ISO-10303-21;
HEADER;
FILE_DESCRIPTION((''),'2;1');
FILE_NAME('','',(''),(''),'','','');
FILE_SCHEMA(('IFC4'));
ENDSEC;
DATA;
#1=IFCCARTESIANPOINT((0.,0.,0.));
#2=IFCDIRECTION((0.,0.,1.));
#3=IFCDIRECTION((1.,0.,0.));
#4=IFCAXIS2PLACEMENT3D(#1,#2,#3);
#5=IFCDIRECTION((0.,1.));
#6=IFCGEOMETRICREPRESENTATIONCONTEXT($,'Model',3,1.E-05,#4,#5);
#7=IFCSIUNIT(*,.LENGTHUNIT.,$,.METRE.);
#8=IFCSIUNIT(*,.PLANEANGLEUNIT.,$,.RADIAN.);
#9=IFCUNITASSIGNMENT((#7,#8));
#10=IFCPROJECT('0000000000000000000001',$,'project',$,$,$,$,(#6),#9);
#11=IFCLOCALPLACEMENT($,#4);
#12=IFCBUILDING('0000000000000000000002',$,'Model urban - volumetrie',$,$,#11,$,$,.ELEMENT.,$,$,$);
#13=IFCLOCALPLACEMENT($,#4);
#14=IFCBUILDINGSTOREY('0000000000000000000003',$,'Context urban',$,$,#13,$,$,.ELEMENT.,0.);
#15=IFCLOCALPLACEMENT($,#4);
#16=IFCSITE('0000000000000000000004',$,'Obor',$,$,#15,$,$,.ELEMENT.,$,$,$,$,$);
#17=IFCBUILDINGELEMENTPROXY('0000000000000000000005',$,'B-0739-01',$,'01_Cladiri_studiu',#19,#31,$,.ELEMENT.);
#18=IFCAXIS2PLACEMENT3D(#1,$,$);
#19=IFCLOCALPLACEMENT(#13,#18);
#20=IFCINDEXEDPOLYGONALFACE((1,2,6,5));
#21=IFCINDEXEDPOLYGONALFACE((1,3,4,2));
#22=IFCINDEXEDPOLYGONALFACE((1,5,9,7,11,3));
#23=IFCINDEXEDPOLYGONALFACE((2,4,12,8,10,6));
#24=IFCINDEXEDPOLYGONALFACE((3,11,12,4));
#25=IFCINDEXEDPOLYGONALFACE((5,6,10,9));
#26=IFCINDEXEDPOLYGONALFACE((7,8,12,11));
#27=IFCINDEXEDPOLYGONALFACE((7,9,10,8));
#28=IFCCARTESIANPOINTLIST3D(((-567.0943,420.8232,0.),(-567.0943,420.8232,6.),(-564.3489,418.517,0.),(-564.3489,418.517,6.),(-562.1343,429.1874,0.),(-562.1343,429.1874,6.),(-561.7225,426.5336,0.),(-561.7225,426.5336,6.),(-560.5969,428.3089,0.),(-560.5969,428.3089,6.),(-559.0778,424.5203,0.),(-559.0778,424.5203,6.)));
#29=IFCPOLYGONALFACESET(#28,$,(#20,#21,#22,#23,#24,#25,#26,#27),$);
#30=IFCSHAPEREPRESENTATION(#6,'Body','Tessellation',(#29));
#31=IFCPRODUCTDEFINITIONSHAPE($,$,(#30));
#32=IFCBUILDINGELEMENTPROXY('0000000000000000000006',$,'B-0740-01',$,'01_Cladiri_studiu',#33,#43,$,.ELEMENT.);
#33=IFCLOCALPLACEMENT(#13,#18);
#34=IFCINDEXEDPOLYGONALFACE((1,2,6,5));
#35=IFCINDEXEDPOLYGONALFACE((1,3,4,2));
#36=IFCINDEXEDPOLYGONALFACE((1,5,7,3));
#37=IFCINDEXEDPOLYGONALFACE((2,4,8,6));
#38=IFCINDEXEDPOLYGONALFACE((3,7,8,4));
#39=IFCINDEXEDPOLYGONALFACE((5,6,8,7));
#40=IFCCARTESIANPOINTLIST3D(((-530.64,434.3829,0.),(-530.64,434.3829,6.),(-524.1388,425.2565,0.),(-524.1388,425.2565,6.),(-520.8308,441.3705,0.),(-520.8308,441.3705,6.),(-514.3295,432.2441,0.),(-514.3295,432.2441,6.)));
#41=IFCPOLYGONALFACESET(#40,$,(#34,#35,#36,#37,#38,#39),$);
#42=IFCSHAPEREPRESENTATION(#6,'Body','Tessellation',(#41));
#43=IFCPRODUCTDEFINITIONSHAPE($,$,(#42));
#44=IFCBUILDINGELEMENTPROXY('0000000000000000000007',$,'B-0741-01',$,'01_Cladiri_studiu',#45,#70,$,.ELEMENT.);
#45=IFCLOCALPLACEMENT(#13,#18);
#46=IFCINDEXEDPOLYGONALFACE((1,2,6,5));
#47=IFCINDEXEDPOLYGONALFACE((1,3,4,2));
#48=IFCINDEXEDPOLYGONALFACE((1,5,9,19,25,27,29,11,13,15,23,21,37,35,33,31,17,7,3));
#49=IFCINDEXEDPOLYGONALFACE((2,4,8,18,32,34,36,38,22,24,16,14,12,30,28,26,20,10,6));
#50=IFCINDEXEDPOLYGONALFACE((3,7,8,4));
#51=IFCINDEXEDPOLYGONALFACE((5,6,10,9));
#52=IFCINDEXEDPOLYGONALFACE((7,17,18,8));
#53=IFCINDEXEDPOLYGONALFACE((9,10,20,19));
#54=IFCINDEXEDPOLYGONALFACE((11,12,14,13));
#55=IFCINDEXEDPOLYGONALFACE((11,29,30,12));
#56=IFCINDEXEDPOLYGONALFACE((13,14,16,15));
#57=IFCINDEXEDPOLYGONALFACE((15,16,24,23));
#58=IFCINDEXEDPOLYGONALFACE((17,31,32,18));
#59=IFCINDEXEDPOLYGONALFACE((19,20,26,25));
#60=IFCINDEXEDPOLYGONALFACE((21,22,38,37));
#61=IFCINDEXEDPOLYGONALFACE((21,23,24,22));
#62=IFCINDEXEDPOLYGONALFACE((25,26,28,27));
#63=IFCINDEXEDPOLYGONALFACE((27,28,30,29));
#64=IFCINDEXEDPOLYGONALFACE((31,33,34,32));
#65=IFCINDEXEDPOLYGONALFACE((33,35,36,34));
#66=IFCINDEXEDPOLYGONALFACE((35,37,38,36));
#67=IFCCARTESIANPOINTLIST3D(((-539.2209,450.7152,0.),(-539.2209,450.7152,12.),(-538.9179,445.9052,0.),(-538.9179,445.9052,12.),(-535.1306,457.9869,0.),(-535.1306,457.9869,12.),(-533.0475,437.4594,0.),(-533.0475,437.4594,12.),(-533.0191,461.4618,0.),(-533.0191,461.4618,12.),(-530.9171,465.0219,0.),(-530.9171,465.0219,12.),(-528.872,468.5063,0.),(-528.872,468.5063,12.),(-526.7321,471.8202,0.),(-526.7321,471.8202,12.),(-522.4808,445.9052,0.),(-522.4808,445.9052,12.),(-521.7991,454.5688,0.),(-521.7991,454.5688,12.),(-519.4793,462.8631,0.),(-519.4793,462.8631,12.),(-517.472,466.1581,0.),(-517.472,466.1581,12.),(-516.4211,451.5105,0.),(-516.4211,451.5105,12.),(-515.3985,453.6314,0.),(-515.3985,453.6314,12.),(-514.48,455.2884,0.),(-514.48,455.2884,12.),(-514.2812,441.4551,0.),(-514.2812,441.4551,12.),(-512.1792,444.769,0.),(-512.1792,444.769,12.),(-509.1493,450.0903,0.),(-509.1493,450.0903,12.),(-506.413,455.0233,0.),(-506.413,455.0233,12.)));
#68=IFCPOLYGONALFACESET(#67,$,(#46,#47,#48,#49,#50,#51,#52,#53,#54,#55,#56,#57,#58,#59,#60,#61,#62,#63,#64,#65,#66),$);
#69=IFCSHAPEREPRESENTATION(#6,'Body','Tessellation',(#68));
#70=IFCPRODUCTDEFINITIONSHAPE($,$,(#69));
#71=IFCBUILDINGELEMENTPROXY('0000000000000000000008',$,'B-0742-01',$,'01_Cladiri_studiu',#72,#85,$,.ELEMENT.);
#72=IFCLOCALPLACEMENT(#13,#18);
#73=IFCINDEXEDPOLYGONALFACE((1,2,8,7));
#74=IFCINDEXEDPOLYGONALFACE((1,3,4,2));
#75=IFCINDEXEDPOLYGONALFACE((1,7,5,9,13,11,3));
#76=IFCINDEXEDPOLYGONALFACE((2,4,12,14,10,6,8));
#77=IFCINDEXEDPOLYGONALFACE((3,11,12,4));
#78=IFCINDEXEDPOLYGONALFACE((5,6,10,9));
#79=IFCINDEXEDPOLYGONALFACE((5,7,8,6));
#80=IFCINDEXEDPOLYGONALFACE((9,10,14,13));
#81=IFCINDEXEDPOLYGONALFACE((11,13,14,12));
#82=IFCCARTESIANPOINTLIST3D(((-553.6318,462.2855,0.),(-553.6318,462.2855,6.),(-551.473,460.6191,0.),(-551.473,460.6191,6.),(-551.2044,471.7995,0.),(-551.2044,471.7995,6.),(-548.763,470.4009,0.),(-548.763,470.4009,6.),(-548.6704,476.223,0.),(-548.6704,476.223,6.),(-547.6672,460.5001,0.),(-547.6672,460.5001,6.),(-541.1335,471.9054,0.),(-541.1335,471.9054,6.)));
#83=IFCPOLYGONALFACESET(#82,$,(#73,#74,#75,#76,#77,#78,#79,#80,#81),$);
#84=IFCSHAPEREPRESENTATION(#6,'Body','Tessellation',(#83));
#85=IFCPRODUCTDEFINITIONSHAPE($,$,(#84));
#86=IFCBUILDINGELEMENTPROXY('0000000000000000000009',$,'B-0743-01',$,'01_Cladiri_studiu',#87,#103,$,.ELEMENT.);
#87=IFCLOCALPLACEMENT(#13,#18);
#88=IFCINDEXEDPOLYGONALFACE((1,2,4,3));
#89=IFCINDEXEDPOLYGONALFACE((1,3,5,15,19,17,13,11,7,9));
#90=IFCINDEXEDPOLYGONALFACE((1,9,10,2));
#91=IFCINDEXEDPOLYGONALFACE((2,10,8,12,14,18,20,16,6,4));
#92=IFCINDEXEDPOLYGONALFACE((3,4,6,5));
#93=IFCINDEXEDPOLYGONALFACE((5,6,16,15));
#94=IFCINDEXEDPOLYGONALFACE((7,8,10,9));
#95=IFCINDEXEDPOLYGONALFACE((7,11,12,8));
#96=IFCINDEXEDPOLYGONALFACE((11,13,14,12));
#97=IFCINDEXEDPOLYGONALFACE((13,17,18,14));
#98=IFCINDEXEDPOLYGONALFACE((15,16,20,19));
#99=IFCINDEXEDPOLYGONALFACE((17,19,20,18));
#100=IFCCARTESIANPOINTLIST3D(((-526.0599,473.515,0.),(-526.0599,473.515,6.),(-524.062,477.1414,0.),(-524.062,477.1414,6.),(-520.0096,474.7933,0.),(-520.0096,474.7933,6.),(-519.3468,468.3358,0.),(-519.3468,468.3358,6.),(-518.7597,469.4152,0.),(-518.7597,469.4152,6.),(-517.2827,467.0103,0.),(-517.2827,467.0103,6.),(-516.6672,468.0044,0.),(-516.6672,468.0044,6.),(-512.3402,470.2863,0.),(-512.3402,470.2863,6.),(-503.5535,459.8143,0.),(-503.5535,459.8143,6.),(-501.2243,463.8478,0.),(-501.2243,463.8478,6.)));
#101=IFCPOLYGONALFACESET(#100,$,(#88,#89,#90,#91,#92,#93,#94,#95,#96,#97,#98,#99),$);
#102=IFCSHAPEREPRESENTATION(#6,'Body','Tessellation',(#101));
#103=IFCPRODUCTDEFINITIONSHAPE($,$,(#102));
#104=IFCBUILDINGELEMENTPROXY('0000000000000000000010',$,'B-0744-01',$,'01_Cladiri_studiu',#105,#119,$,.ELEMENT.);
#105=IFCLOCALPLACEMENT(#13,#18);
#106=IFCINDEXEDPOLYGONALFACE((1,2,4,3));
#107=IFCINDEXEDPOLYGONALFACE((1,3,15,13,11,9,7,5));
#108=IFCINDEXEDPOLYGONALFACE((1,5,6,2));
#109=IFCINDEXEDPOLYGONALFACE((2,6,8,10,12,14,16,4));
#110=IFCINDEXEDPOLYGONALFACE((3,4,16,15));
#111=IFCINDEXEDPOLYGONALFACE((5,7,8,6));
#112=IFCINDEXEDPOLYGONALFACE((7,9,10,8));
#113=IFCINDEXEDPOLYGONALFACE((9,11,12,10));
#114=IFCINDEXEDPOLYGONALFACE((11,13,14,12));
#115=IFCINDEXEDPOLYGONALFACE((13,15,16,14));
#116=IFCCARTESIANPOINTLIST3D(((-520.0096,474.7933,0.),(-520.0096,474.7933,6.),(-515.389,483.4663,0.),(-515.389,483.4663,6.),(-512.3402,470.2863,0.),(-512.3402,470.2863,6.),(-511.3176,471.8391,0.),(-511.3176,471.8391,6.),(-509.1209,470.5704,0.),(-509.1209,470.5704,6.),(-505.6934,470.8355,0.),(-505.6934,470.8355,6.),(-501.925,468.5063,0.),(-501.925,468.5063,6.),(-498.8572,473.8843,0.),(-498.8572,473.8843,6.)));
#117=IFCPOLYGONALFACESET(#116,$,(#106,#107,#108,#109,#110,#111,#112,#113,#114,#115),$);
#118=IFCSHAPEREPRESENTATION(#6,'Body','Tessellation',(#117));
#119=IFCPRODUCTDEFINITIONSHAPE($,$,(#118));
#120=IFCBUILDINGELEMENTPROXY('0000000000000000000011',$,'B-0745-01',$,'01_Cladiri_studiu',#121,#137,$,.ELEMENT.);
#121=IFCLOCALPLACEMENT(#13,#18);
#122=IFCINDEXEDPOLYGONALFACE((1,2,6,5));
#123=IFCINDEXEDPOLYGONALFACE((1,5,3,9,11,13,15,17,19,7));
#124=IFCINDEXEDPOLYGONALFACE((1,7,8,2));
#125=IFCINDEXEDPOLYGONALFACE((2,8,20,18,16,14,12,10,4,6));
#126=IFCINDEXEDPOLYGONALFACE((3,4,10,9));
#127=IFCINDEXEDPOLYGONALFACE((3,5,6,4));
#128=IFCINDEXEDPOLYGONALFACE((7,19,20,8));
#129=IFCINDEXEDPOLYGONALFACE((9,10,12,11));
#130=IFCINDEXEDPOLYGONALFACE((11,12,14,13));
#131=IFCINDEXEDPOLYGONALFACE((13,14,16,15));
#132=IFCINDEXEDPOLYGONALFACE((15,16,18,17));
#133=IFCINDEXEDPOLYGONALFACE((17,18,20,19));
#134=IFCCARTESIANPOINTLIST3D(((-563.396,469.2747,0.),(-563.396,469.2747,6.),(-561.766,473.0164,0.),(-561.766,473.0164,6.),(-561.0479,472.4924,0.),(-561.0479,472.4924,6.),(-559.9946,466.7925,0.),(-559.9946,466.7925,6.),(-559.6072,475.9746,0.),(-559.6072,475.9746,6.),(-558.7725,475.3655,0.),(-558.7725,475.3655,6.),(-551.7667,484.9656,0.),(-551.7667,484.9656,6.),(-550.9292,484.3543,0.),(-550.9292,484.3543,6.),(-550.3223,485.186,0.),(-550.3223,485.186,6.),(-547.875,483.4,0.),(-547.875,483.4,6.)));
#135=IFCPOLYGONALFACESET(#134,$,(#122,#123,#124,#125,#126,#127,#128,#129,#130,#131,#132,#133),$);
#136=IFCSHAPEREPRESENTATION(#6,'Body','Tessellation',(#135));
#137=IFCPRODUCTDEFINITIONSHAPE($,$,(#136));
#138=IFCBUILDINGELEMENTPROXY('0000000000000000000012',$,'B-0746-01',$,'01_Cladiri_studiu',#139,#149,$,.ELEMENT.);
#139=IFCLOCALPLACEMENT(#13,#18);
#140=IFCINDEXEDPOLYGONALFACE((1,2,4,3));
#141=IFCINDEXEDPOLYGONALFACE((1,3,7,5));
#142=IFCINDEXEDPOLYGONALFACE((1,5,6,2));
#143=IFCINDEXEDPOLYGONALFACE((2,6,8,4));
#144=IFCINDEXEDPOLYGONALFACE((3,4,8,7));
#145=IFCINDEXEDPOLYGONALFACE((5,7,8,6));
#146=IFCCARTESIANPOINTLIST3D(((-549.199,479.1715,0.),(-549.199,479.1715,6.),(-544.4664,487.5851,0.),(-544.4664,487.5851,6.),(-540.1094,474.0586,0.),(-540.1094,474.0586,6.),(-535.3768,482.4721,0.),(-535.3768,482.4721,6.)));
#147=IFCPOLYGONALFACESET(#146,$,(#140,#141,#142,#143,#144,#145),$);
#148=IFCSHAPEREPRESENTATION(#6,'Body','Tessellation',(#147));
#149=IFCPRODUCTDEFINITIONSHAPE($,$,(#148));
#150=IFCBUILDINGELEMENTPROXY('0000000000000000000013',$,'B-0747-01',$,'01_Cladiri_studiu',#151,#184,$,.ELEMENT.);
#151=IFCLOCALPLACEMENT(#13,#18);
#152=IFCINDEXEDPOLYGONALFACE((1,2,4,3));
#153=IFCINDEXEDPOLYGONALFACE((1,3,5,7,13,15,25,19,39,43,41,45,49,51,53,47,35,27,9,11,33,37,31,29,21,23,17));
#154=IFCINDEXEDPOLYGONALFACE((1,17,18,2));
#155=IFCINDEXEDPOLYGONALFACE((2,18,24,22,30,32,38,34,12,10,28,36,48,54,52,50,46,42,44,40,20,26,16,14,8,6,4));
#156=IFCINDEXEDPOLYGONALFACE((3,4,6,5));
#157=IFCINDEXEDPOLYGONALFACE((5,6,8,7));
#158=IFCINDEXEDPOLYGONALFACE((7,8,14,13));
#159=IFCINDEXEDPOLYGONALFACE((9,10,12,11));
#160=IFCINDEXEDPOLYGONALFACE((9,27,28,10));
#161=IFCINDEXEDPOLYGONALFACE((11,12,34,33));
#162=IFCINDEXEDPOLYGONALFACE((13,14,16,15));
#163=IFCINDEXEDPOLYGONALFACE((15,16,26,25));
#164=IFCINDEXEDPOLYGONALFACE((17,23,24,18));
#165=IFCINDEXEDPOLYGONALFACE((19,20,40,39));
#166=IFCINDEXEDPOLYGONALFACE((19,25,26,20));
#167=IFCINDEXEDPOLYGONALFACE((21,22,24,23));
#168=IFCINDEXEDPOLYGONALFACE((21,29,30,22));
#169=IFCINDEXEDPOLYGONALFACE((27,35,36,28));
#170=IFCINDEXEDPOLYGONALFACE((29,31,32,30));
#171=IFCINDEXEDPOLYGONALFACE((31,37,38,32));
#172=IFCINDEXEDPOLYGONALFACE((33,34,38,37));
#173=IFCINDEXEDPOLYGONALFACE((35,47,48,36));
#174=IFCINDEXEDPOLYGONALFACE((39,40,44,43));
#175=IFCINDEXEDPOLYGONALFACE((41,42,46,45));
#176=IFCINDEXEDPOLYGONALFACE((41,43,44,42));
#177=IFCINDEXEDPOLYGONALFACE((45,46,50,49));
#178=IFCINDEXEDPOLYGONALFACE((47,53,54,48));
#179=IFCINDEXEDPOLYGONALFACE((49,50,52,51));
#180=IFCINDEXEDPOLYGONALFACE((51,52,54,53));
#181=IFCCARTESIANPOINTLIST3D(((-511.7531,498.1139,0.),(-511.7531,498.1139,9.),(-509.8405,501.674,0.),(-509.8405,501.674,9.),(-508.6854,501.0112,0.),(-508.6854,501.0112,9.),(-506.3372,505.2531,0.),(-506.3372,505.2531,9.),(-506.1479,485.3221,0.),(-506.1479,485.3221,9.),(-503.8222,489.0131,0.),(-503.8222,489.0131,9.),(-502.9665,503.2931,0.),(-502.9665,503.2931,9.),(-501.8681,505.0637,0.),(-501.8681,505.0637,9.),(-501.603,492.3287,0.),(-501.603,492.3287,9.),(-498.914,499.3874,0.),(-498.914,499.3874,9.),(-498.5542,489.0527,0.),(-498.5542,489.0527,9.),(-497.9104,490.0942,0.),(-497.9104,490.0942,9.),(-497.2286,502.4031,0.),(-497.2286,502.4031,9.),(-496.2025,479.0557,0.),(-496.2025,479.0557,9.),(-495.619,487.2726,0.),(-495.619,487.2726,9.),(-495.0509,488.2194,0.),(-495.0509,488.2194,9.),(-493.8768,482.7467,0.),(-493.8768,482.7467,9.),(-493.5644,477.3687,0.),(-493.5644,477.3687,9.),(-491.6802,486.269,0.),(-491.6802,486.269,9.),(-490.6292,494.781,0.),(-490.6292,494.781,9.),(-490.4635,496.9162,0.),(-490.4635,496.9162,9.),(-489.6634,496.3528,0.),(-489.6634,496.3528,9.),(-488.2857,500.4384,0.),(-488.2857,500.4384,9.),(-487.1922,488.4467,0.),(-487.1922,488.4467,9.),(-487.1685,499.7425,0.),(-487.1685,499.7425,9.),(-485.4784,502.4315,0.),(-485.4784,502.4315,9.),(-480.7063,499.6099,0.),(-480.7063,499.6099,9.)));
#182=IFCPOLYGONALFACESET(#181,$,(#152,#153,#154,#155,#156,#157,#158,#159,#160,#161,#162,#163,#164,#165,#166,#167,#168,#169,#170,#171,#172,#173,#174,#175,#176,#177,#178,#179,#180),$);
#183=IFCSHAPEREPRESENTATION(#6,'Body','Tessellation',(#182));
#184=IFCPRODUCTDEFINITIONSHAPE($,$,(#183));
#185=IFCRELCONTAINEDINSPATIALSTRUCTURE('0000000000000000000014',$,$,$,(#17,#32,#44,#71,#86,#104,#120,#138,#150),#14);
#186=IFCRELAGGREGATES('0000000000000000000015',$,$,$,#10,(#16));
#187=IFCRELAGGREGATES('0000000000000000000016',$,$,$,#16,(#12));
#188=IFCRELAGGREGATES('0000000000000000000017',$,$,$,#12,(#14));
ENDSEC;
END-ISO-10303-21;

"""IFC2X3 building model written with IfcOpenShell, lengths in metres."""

from ifc_helpers import new_model, si_unit, direction, origin_with_axes, place, context, project, spatial, polyline, outline, extrude, element, save


model = new_model("IFC2X3")

# Units and contexts
model_context = context("Model", 3, precision=1e-05, world=origin_with_axes(), true_north=direction((0.0, 1.0)))
ifc_project = project(units=[si_unit("LENGTHUNIT", "METRE"), si_unit("PLANEANGLEUNIT", "RADIAN")], contexts=[model_context])

# Site, building, storey
site_placement = place(None, origin_with_axes())
site = spatial("IfcSite", under=ifc_project, at=site_placement, Name="Obor", CompositionType="ELEMENT")
building_placement = place(None, origin_with_axes())
building = spatial("IfcBuilding", under=site, at=building_placement, Name="Model urban - volumetrie", CompositionType="ELEMENT")
storey_placement = place(None, origin_with_axes())
storey = spatial("IfcBuildingStorey", under=building, at=storey_placement, Name="Context urban", CompositionType="ELEMENT", Elevation=0.0)

# Building element proxies
proxy_1_placement = place(None, origin_with_axes())
element("IfcBuildingElementProxy", 1, at=proxy_1_placement, inside=storey, Name="B-0739-01", ObjectType="01_Cladiri_studiu", CompositionType="ELEMENT", context=model_context, shape_type="SweptSolid", body=[
    extrude(outline(polyline([(-560.5969, 428.3089), (-562.1343, 429.1874), (-567.0943, 420.8232), (-564.3489, 418.517), (-559.0778, 424.5203), (-561.7225, 426.5336), (-560.5969, 428.3089)])), origin_with_axes(), (0.0, 0.0, 1.0), 6.0),
])
proxy_2_placement = place(None, origin_with_axes())
element("IfcBuildingElementProxy", 2, at=proxy_2_placement, inside=storey, Name="B-0740-01", ObjectType="01_Cladiri_studiu", CompositionType="ELEMENT", context=model_context, shape_type="SweptSolid", body=[
    extrude(outline(polyline([(-514.3295, 432.2441), (-520.8308, 441.3705), (-530.64, 434.3829), (-524.1388, 425.2565), (-514.3295, 432.2441)])), origin_with_axes(), (0.0, 0.0, 1.0), 6.0),
])
proxy_3_placement = place(None, origin_with_axes())
element("IfcBuildingElementProxy", 3, at=proxy_3_placement, inside=storey, Name="B-0741-01", ObjectType="01_Cladiri_studiu", CompositionType="ELEMENT", context=model_context, shape_type="SweptSolid", body=[
    extrude(outline(polyline([(-517.472, 466.1581), (-526.7321, 471.8202), (-528.872, 468.5063), (-530.9171, 465.0219), (-514.48, 455.2884), (-515.3985, 453.6314), (-516.4211, 451.5105), (-521.7991, 454.5688), (-533.0191, 461.4618), (-535.1306, 457.9869), (-539.2209, 450.7152), (-538.9179, 445.9052), (-533.0475, 437.4594), (-522.4808, 445.9052), (-514.2812, 441.4551), (-512.1792, 444.769), (-509.1493, 450.0903), (-506.413, 455.0233), (-519.4793, 462.8631), (-517.472, 466.1581)])), origin_with_axes(), (0.0, 0.0, 1.0), 12.0),
])
proxy_4_placement = place(None, origin_with_axes())
element("IfcBuildingElementProxy", 4, at=proxy_4_placement, inside=storey, Name="B-0742-01", ObjectType="01_Cladiri_studiu", CompositionType="ELEMENT", context=model_context, shape_type="SweptSolid", body=[
    extrude(outline(polyline([(-541.1335, 471.9054), (-548.6704, 476.223), (-551.2044, 471.7995), (-548.763, 470.4009), (-553.6318, 462.2855), (-551.473, 460.6191), (-547.6672, 460.5001), (-541.1335, 471.9054)])), origin_with_axes(), (0.0, 0.0, 1.0), 6.0),
])
proxy_5_placement = place(None, origin_with_axes())
element("IfcBuildingElementProxy", 5, at=proxy_5_placement, inside=storey, Name="B-0743-01", ObjectType="01_Cladiri_studiu", CompositionType="ELEMENT", context=model_context, shape_type="SweptSolid", body=[
    extrude(outline(polyline([(-516.6672, 468.0044), (-503.5535, 459.8143), (-501.2243, 463.8478), (-512.3402, 470.2863), (-520.0096, 474.7933), (-524.062, 477.1414), (-526.0599, 473.515), (-518.7597, 469.4152), (-519.3468, 468.3358), (-517.2827, 467.0103), (-516.6672, 468.0044)])), origin_with_axes(), (0.0, 0.0, 1.0), 6.0),
])
proxy_6_placement = place(None, origin_with_axes())
element("IfcBuildingElementProxy", 6, at=proxy_6_placement, inside=storey, Name="B-0744-01", ObjectType="01_Cladiri_studiu", CompositionType="ELEMENT", context=model_context, shape_type="SweptSolid", body=[
    extrude(outline(polyline([(-511.3176, 471.8391), (-509.1209, 470.5704), (-505.6934, 470.8355), (-501.925, 468.5063), (-498.8572, 473.8843), (-515.389, 483.4663), (-520.0096, 474.7933), (-512.3402, 470.2863), (-511.3176, 471.8391)])), origin_with_axes(), (0.0, 0.0, 1.0), 6.0),
])
proxy_7_placement = place(None, origin_with_axes())
element("IfcBuildingElementProxy", 7, at=proxy_7_placement, inside=storey, Name="B-0745-01", ObjectType="01_Cladiri_studiu", CompositionType="ELEMENT", context=model_context, shape_type="SweptSolid", body=[
    extrude(outline(polyline([(-559.6072, 475.9746), (-561.766, 473.0164), (-561.0479, 472.4924), (-563.396, 469.2747), (-559.9946, 466.7925), (-547.875, 483.4), (-550.3223, 485.186), (-550.9292, 484.3543), (-551.7667, 484.9656), (-558.7725, 475.3655), (-559.6072, 475.9746)])), origin_with_axes(), (0.0, 0.0, 1.0), 6.0),
])
proxy_8_placement = place(None, origin_with_axes())
element("IfcBuildingElementProxy", 8, at=proxy_8_placement, inside=storey, Name="B-0746-01", ObjectType="01_Cladiri_studiu", CompositionType="ELEMENT", context=model_context, shape_type="SweptSolid", body=[
    extrude(outline(polyline([(-540.1094, 474.0586), (-535.3768, 482.4721), (-544.4664, 487.5851), (-549.199, 479.1715), (-540.1094, 474.0586)])), origin_with_axes(), (0.0, 0.0, 1.0), 6.0),
])
proxy_9_placement = place(None, origin_with_axes())
element("IfcBuildingElementProxy", 9, at=proxy_9_placement, inside=storey, Name="B-0747-01", ObjectType="01_Cladiri_studiu", CompositionType="ELEMENT", context=model_context, shape_type="SweptSolid", body=[
    extrude(outline(polyline([(-495.0509, 488.2194), (-491.6802, 486.269), (-493.8768, 482.7467), (-503.8222, 489.0131), (-506.1479, 485.3221), (-496.2025, 479.0557), (-493.5644, 477.3687), (-487.1922, 488.4467), (-480.7063, 499.6099), (-485.4784, 502.4315), (-487.1685, 499.7425), (-488.2857, 500.4384), (-490.4635, 496.9162), (-489.6634, 496.3528), (-490.6292, 494.781), (-498.914, 499.3874), (-497.2286, 502.4031), (-501.8681, 505.0637), (-502.9665, 503.2931), (-506.3372, 505.2531), (-508.6854, 501.0112), (-509.8405, 501.674), (-511.7531, 498.1139), (-501.603, 492.3287), (-497.9104, 490.0942), (-498.5542, 489.0527), (-495.619, 487.2726), (-495.0509, 488.2194)]), holes=[polyline([(-492.4471, 491.5807), (-487.1922, 488.4467), (-492.4471, 491.5807), (-499.4632, 495.7184), (-492.4471, 491.5807)])]), origin_with_axes(), (0.0, 0.0, 1.0), 9.0),
])

save(model, "model.ifc")
